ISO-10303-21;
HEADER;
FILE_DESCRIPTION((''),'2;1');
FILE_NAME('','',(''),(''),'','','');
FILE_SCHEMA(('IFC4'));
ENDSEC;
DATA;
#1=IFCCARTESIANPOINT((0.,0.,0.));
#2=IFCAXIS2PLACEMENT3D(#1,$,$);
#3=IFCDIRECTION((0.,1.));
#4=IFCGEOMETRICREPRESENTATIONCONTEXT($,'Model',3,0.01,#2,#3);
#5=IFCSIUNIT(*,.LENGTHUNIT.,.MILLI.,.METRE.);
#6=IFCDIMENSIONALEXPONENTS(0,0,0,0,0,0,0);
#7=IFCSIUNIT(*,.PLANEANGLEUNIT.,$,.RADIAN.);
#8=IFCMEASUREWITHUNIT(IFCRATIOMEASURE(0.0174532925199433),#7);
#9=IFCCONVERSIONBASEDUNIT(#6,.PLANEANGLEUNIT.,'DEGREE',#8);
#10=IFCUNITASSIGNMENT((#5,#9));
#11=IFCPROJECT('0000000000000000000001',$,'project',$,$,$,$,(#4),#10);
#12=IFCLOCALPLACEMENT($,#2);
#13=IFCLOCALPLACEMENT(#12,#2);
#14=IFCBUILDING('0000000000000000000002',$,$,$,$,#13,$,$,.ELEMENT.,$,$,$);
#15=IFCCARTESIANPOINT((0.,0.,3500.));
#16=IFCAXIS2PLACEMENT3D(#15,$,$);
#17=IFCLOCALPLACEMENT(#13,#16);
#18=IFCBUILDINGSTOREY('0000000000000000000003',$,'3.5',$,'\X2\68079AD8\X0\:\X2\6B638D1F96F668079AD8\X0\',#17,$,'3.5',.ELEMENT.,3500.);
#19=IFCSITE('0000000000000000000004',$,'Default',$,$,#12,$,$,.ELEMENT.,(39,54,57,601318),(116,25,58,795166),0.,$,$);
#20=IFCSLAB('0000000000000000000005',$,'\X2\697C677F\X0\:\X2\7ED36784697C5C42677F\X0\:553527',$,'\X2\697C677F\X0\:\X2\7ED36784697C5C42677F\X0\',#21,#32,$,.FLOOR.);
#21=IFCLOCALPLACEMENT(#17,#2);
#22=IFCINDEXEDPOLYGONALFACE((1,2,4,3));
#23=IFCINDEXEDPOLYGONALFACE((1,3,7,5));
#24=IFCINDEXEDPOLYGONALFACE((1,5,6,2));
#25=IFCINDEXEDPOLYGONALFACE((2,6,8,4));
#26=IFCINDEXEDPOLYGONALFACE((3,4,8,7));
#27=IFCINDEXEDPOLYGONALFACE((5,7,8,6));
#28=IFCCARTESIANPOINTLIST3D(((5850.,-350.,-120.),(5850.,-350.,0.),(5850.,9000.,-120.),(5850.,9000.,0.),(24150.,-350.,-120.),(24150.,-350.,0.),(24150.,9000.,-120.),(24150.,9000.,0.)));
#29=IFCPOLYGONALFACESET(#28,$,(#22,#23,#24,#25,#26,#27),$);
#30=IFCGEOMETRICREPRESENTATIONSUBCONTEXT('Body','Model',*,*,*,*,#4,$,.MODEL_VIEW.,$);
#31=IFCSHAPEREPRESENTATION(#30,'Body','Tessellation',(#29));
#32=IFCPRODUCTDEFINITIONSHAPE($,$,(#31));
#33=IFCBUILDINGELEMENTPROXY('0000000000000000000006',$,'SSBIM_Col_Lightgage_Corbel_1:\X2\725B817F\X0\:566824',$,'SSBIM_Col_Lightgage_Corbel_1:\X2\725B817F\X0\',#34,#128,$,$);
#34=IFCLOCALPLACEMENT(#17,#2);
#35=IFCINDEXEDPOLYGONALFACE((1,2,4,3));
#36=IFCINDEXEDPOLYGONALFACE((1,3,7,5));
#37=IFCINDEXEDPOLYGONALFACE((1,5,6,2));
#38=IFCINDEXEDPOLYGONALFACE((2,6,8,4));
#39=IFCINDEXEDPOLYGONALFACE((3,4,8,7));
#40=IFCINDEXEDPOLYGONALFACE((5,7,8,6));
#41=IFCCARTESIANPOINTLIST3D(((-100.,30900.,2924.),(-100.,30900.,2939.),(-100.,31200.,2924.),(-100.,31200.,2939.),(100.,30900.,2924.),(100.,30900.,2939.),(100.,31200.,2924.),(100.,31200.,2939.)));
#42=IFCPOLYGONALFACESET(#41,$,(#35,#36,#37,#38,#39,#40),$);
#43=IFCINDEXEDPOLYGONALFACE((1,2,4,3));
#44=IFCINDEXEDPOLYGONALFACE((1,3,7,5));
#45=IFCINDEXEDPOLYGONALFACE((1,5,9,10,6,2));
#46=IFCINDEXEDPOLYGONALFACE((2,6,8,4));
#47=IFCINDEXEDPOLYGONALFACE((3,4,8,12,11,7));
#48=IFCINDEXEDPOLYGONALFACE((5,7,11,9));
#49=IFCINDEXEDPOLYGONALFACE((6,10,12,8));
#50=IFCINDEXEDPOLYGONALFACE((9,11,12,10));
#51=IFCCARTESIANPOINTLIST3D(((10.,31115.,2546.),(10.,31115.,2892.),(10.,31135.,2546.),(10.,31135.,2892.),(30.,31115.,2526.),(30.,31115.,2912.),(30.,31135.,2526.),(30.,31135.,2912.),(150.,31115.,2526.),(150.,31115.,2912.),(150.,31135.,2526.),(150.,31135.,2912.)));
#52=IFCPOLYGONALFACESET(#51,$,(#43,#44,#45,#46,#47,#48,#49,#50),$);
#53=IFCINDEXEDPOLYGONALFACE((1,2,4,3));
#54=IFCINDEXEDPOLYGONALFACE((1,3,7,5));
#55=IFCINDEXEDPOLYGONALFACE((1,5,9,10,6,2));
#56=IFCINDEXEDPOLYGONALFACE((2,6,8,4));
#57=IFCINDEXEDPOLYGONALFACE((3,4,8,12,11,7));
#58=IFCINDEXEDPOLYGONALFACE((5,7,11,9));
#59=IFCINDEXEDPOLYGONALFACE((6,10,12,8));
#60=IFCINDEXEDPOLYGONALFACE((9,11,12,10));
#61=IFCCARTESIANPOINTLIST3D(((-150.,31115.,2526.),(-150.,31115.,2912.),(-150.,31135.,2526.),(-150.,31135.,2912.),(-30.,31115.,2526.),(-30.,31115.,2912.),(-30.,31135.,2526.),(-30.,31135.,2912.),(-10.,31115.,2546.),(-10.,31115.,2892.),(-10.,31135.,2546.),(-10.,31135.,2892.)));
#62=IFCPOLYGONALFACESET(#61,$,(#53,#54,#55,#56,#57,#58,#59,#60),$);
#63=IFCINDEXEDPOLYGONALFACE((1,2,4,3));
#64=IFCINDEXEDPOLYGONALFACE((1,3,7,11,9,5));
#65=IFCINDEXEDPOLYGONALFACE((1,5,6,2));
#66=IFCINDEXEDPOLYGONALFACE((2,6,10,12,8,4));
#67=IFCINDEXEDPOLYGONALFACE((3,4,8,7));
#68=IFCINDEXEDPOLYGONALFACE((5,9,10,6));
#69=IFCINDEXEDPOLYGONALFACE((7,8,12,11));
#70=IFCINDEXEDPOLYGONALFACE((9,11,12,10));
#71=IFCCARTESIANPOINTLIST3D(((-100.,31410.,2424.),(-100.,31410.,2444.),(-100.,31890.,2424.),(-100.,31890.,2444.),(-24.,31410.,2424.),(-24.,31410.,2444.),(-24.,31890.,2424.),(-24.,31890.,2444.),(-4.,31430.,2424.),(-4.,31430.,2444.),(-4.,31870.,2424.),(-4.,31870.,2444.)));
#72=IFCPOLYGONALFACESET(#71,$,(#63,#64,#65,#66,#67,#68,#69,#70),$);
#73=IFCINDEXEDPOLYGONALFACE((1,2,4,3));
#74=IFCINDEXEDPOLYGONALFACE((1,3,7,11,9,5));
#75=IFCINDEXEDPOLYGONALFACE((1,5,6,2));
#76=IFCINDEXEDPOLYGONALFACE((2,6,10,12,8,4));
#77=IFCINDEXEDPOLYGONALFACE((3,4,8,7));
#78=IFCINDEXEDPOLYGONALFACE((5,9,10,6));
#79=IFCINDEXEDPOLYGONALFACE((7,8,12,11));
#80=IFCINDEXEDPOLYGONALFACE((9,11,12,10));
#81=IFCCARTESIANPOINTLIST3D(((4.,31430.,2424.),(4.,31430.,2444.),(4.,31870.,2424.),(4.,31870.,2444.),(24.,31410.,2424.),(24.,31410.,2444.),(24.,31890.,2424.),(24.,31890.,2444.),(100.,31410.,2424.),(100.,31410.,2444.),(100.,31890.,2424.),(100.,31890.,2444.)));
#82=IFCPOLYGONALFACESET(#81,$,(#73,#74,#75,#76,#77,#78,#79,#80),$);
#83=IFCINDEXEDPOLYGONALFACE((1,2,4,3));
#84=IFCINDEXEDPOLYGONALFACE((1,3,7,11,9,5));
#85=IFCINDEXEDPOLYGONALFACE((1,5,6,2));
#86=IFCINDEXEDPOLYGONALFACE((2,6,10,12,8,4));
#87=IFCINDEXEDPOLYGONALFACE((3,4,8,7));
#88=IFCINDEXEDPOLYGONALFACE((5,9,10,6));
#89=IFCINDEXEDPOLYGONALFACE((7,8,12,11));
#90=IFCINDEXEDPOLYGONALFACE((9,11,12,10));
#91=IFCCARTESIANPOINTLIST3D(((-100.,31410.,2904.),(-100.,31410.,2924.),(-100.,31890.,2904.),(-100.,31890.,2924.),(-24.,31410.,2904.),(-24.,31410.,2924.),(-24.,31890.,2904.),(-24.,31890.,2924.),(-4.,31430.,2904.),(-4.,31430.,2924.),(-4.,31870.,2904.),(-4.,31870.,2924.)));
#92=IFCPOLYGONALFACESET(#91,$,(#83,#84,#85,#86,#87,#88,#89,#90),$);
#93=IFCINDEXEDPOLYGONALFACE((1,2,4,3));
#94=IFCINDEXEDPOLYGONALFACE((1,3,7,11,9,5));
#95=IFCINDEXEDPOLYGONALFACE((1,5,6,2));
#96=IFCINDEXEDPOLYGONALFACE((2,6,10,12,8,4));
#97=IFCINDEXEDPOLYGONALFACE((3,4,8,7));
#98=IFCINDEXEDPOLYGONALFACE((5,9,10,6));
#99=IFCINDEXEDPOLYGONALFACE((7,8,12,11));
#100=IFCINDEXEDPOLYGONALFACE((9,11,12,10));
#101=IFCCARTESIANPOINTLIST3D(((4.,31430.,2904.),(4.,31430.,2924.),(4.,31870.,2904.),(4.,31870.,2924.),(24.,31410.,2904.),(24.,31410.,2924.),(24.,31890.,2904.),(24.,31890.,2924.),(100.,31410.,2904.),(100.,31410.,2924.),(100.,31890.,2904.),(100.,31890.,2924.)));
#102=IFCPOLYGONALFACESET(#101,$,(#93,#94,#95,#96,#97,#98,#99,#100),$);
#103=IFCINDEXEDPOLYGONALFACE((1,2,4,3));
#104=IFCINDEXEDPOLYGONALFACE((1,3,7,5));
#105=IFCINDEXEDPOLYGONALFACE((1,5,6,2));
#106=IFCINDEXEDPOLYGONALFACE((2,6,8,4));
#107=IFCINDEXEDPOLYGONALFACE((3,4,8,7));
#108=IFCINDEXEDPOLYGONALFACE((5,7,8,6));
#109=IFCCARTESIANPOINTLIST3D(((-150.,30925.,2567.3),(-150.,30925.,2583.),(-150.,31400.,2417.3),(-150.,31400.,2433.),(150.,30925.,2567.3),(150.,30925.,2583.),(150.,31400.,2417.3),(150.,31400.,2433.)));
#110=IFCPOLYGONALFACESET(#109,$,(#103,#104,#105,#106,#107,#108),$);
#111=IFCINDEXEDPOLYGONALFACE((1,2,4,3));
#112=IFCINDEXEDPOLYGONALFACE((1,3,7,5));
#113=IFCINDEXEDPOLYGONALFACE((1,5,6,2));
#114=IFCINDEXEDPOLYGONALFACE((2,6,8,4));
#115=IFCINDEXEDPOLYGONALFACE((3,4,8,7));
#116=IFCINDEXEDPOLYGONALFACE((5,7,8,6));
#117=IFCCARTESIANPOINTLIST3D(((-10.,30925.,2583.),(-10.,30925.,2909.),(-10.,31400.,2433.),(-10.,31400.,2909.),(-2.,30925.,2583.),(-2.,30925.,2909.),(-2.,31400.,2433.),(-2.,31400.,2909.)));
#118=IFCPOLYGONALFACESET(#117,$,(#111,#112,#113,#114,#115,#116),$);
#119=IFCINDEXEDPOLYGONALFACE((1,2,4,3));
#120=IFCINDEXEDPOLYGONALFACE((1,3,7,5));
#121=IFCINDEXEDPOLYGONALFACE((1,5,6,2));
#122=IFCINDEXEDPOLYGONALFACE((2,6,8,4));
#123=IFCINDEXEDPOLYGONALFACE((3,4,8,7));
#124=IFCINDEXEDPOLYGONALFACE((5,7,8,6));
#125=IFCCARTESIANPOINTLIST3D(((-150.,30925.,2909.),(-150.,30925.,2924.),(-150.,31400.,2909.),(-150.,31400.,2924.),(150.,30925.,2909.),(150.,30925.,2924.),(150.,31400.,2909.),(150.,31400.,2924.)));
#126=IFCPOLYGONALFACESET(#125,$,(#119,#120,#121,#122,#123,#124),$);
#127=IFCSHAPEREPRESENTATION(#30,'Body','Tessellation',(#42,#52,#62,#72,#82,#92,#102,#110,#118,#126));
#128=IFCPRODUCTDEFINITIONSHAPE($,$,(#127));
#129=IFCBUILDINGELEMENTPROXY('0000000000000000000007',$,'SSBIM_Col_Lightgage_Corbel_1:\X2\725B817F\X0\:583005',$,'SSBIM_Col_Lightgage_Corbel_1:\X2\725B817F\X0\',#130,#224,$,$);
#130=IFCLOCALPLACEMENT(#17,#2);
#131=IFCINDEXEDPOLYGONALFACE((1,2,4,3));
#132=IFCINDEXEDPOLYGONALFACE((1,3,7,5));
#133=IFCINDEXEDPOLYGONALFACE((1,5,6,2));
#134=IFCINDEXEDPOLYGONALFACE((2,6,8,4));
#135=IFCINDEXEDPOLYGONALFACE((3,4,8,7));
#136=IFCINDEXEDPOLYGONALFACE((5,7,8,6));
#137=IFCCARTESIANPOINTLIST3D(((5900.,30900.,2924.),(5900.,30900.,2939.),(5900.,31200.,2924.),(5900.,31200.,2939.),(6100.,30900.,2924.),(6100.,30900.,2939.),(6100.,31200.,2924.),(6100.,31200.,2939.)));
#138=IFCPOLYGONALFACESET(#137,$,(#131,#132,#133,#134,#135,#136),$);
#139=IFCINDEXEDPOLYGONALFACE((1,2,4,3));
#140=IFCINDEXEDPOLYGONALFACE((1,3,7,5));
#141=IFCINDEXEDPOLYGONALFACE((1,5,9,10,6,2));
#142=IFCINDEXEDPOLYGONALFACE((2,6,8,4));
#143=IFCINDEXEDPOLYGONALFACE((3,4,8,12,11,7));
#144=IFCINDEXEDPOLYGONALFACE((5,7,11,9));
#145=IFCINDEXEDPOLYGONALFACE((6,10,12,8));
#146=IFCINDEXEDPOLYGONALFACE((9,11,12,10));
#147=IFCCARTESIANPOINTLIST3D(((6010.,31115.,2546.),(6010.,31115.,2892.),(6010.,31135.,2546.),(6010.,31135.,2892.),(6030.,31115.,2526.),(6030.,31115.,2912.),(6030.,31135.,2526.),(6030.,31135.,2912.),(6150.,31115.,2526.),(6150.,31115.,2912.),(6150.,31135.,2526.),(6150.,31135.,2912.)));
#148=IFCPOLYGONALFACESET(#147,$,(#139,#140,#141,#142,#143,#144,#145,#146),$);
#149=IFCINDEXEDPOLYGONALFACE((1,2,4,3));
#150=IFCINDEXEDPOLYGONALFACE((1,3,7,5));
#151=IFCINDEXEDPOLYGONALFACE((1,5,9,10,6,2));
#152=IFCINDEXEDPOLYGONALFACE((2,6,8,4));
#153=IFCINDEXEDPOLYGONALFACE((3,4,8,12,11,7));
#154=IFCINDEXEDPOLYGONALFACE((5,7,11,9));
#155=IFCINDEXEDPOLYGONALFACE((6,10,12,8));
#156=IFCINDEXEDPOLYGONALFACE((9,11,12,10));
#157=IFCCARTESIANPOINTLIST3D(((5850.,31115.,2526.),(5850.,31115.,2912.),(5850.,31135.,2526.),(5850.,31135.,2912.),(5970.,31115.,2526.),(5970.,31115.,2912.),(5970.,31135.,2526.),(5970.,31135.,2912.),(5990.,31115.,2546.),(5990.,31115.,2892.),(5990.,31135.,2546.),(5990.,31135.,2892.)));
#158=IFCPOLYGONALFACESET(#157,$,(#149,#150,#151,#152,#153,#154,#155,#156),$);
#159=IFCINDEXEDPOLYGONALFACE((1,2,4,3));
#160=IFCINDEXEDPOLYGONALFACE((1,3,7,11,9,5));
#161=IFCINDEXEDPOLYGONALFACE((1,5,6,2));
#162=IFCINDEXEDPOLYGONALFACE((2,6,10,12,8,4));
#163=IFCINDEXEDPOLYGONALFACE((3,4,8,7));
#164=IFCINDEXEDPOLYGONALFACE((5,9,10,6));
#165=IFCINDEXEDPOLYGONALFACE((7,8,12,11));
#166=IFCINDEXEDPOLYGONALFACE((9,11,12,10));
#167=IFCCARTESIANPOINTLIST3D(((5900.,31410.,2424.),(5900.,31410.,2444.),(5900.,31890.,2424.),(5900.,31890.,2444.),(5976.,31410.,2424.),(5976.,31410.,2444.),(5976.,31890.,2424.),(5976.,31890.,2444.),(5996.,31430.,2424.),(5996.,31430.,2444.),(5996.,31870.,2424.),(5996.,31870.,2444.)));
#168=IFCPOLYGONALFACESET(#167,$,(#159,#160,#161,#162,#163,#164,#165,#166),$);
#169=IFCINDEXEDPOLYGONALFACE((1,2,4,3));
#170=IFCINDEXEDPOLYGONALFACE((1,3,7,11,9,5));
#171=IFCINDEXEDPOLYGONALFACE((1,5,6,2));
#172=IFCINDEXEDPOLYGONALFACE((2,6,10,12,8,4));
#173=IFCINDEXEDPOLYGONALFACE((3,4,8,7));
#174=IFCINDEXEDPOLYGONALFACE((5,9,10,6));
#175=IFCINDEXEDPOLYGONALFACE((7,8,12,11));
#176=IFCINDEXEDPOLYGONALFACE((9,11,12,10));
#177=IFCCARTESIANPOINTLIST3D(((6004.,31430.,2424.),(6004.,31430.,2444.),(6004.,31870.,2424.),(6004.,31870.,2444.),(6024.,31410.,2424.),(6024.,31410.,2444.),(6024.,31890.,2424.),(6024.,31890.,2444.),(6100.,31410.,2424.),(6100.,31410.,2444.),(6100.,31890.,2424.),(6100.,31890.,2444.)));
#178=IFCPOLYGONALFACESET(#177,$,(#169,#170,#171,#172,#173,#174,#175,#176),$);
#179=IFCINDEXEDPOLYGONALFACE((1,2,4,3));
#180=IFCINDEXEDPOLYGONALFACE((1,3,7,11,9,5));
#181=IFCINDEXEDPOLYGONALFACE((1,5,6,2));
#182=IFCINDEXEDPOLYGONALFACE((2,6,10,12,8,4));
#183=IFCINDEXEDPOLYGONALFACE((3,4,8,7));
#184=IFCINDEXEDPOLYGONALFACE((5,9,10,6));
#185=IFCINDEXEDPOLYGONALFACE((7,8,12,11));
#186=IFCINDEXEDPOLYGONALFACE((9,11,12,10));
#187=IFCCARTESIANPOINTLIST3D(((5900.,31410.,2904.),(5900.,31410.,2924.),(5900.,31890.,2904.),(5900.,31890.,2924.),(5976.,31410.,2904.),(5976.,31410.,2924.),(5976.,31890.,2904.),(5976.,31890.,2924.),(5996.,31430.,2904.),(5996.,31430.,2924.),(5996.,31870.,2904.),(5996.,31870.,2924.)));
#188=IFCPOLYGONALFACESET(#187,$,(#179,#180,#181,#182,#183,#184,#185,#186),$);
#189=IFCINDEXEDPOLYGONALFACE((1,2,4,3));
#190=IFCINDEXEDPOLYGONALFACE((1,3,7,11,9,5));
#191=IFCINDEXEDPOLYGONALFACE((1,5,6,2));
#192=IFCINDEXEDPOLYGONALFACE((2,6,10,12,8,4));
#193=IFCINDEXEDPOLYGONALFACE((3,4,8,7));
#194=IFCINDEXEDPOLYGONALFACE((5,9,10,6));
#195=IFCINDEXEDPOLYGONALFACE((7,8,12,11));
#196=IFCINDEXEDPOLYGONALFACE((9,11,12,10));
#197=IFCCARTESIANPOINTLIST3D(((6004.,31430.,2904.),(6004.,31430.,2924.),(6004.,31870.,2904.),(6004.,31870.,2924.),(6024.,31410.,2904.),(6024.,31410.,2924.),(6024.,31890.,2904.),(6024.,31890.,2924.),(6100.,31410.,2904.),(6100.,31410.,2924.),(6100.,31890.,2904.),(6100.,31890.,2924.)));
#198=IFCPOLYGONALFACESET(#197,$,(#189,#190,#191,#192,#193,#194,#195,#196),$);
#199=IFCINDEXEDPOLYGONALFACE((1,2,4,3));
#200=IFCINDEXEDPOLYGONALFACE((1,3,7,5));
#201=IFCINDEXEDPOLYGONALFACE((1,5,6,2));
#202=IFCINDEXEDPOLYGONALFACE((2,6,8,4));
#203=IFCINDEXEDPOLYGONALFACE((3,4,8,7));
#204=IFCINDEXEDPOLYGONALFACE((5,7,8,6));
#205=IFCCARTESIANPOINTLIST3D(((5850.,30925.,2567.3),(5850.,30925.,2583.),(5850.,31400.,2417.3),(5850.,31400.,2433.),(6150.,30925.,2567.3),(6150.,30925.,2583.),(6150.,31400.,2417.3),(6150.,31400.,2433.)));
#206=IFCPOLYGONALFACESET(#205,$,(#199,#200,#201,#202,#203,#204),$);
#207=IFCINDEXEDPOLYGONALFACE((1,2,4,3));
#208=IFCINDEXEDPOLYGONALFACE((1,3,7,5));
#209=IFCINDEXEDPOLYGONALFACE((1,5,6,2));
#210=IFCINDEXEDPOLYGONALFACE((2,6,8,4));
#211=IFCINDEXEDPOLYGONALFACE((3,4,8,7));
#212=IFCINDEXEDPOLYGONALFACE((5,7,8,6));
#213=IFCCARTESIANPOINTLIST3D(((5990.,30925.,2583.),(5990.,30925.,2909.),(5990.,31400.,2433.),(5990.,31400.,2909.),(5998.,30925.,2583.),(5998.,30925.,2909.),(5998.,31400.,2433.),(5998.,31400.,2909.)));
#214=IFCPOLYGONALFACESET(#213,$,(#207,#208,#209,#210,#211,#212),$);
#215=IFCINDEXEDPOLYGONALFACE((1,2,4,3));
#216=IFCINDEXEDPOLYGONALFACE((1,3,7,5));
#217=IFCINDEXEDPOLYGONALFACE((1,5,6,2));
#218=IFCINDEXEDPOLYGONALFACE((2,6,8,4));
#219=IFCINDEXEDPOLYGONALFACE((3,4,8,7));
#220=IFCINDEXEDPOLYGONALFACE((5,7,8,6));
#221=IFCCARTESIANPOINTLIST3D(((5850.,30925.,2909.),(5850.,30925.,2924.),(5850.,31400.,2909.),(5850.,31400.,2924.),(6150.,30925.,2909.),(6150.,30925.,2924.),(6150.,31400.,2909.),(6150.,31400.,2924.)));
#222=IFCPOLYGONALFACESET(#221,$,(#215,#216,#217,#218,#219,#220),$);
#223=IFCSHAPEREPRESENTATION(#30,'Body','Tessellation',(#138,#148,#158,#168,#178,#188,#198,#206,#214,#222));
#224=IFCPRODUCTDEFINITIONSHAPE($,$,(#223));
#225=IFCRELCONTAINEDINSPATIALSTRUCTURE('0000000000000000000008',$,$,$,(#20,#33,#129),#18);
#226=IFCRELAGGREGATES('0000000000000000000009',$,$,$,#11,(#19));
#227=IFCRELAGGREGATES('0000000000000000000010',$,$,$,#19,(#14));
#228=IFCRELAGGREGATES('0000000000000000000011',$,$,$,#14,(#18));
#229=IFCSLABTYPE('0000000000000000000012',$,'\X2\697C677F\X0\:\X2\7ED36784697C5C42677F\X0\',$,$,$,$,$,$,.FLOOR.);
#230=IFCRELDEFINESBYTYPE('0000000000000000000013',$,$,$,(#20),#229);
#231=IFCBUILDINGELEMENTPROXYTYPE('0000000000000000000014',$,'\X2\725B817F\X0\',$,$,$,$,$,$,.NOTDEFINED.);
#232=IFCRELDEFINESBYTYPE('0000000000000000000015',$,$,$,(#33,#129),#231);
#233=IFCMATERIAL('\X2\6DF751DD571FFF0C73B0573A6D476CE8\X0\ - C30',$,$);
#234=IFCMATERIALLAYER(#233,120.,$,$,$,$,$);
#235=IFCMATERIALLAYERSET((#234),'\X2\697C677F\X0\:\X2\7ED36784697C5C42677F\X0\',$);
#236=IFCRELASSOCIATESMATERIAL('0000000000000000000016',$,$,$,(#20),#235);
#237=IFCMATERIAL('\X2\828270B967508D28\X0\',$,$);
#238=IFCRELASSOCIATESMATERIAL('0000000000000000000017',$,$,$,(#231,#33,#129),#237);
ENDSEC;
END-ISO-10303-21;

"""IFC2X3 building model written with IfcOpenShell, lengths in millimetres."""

from ifc_helpers import new_model, entity, si_unit, converted_unit, direction, frame, frame_2d, origin, origin_2d_with_axis, place, context, subcontext, project, spatial, polyline, rectangle, outline, extrude, source, transform, mapped, material, layer, layer_set, layer_usage, type_object, type_shapes, element, save


model = new_model("IFC2X3")

# Units and contexts
model_context = context("Model", 3, precision=0.01, world=origin(), true_north=direction((0.0, 1.0)))
body_context = subcontext(model_context, "Body", "Model", "MODEL_VIEW")
ifc_project = project(units=[si_unit("LENGTHUNIT", "METRE", prefix="MILLI"), converted_unit("PLANEANGLEUNIT", "DEGREE", entity("IfcRatioMeasure", 0.0174532925199433), si_unit("PLANEANGLEUNIT", "RADIAN"), dimensions=[0, 0, 0, 0, 0, 0, 0])], contexts=[model_context])

# Site, building, storey
site_placement = place(None, origin())
site = spatial("IfcSite", under=ifc_project, at=site_placement, Name="Default", CompositionType="ELEMENT", RefLatitude=(39, 54, 57, 601318), RefLongitude=(116, 25, 58, 795166), RefElevation=0.0)
building_placement = place(site_placement, origin())
building = spatial("IfcBuilding", under=site, at=building_placement, CompositionType="ELEMENT")
storey_placement = place(building_placement, frame((0.0, 0.0, 3500.0)))
storey = spatial("IfcBuildingStorey", under=building, at=storey_placement, Name="3.5", ObjectType="标高:正负零标高", LongName="3.5", CompositionType="ELEMENT", Elevation=3500.0)

# Slab
ifc_material_1 = material(Name="混凝土，现场浇注 - C30")
ifc_layer = layer(ifc_material_1, 120.0)
ifc_layer_set = layer_set([ifc_layer], Name="楼板:结构楼层板")
ifc_layer_usage = layer_usage(ifc_layer_set, "AXIS3", "POSITIVE", 0.0)
slab_type_1 = type_object("IfcSlabType", Name="楼板:结构楼层板", PredefinedType="FLOOR")
slab_1_placement = place(storey_placement, frame((5850.0, -350.0, -120.0)))
element("IfcSlab", 1, at=slab_1_placement, inside=storey, type_object=slab_type_1, material=ifc_layer_usage, Name="楼板:结构楼层板:553527", ObjectType="楼板:结构楼层板", PredefinedType="FLOOR", context=body_context, shape_type="SweptSolid", body=[
    extrude(rectangle(XDim=9350.0, YDim=18300.0, at=frame_2d((12050.0, 0.0), x_axis=(0.0, -1.0))), frame((21200.0, 4675.0, 120.0), z_axis=(0.0, 0.0, -1.0), x_axis=(-1.0, 0.0, 0.0)), (0.0, 0.0, 1.0), 120.0),
])

# Building element proxies
ifc_material_2 = material(Name="节点材质")
building_element_proxy_type_1 = type_object("IfcBuildingElementProxyType", Name="牛腿", PredefinedType="NOTDEFINED", material=ifc_material_2)
shared_shape_1 = source(origin(), body_context, "Body", "SweptSolid", [
    extrude(rectangle(XDim=300.0, YDim=200.0, at=frame_2d((0.0, 0.0), x_axis=(1.0, 0.0))), frame((636.4, 0.0, 0.0)), (0.0, 0.0, 1.0), 15.0),
    extrude(outline(polyline([(-193.0, -86.7), (193.0, -86.7), (193.0, 33.3), (173.0, 53.3), (-173.0, 53.3), (-193.0, 33.3), (-193.0, -86.7)])), frame((551.4, 63.3, -205.0), z_axis=(1.0, 0.0, 0.0), x_axis=(0.0, 0.0, 1.0)), (0.0, 0.0, 1.0), 20.0),
    extrude(outline(polyline([(-86.7, -193.0), (33.3, -193.0), (53.3, -173.0), (53.3, 173.0), (33.3, 193.0), (-86.7, 193.0), (-86.7, -193.0)])), frame((551.4, -63.3, -205.0), z_axis=(1.0, 0.0, 0.0), x_axis=(0.0, 1.0, 0.0)), (0.0, 0.0, 1.0), 20.0),
    extrude(outline(polyline([(-240.0, -57.3), (240.0, -57.3), (240.0, 18.7), (220.0, 38.7), (-220.0, 38.7), (-240.0, 18.7), (-240.0, -57.3)])), frame((36.4, -42.7, -500.0)), (0.0, 0.0, 1.0), 20.0),
    extrude(outline(polyline([(-57.3, -240.0), (18.7, -240.0), (38.7, -220.0), (38.7, 220.0), (18.7, 240.0), (-57.3, 240.0), (-57.3, -240.0)])), frame((36.4, 42.7, -500.0), z_axis=(0.0, 0.0, 1.0), x_axis=(0.0, -1.0, 0.0)), (0.0, 0.0, 1.0), 20.0),
    extrude(outline(polyline([(-240.0, -57.3), (240.0, -57.3), (240.0, 18.7), (220.0, 38.7), (-220.0, 38.7), (-240.0, 18.7), (-240.0, -57.3)])), frame((36.4, -42.7, -20.0)), (0.0, 0.0, 1.0), 20.0),
    extrude(outline(polyline([(-57.3, -240.0), (18.7, -240.0), (38.7, -220.0), (38.7, 220.0), (18.7, 240.0), (-57.3, 240.0), (-57.3, -240.0)])), frame((36.4, 42.7, -20.0), z_axis=(0.0, 0.0, 1.0), x_axis=(0.0, -1.0, 0.0)), (0.0, 0.0, 1.0), 20.0),
    extrude(outline(polyline([(-246.7, -7.5), (251.4, -7.5), (246.7, 7.5), (-251.4, 7.5), (-246.7, -7.5)])), frame((523.9, -150.0, -423.9), z_axis=(0.0, 1.0, 0.0), x_axis=(0.953583, 0.0, 0.301131)), (0.0, 0.0, 1.0), 300.0),
    extrude(outline(polyline([(-237.5, -200.5), (237.5, -200.5), (237.5, 125.5), (-237.5, 275.5), (-237.5, -200.5)])), frame((523.9, -10.0, -215.5), z_axis=(0.0, 1.0, 0.0), x_axis=(1.0, 0.0, 0.0)), (0.0, 0.0, 1.0), 8.0),
    extrude(rectangle(XDim=475.0, YDim=300.0, at=origin_2d_with_axis()), frame((523.9, 0.0, -15.0)), (0.0, 0.0, 1.0), 15.0),
])
type_shapes(building_element_proxy_type_1, [shared_shape_1])
for number, where, z_axis, x_axis, name in (
    (2, (0.0, 31686.4, 2924.0), (0.0, 0.0, 1.0), (0.0, -1.0, 0.0), "SSBIM_Col_Lightgage_Corbel_1:牛腿:566824"),
    (3, (6000.0, 31686.4, 2924.0), (0.0, 0.0, 1.0), (0.0, -1.0, 0.0), "SSBIM_Col_Lightgage_Corbel_1:牛腿:583005"),
):
    element("IfcBuildingElementProxy", number, at=place(storey_placement, frame(where, z_axis=z_axis, x_axis=x_axis)), inside=storey, type_object=building_element_proxy_type_1, material=ifc_material_2, Name=name, ObjectType="SSBIM_Col_Lightgage_Corbel_1:牛腿", context=body_context, shape_type="MappedRepresentation", body=[
        mapped(shared_shape_1, transform((0.0, 0.0, 0.0), scale=1.0)),
    ])

save(model, "model.ifc")
